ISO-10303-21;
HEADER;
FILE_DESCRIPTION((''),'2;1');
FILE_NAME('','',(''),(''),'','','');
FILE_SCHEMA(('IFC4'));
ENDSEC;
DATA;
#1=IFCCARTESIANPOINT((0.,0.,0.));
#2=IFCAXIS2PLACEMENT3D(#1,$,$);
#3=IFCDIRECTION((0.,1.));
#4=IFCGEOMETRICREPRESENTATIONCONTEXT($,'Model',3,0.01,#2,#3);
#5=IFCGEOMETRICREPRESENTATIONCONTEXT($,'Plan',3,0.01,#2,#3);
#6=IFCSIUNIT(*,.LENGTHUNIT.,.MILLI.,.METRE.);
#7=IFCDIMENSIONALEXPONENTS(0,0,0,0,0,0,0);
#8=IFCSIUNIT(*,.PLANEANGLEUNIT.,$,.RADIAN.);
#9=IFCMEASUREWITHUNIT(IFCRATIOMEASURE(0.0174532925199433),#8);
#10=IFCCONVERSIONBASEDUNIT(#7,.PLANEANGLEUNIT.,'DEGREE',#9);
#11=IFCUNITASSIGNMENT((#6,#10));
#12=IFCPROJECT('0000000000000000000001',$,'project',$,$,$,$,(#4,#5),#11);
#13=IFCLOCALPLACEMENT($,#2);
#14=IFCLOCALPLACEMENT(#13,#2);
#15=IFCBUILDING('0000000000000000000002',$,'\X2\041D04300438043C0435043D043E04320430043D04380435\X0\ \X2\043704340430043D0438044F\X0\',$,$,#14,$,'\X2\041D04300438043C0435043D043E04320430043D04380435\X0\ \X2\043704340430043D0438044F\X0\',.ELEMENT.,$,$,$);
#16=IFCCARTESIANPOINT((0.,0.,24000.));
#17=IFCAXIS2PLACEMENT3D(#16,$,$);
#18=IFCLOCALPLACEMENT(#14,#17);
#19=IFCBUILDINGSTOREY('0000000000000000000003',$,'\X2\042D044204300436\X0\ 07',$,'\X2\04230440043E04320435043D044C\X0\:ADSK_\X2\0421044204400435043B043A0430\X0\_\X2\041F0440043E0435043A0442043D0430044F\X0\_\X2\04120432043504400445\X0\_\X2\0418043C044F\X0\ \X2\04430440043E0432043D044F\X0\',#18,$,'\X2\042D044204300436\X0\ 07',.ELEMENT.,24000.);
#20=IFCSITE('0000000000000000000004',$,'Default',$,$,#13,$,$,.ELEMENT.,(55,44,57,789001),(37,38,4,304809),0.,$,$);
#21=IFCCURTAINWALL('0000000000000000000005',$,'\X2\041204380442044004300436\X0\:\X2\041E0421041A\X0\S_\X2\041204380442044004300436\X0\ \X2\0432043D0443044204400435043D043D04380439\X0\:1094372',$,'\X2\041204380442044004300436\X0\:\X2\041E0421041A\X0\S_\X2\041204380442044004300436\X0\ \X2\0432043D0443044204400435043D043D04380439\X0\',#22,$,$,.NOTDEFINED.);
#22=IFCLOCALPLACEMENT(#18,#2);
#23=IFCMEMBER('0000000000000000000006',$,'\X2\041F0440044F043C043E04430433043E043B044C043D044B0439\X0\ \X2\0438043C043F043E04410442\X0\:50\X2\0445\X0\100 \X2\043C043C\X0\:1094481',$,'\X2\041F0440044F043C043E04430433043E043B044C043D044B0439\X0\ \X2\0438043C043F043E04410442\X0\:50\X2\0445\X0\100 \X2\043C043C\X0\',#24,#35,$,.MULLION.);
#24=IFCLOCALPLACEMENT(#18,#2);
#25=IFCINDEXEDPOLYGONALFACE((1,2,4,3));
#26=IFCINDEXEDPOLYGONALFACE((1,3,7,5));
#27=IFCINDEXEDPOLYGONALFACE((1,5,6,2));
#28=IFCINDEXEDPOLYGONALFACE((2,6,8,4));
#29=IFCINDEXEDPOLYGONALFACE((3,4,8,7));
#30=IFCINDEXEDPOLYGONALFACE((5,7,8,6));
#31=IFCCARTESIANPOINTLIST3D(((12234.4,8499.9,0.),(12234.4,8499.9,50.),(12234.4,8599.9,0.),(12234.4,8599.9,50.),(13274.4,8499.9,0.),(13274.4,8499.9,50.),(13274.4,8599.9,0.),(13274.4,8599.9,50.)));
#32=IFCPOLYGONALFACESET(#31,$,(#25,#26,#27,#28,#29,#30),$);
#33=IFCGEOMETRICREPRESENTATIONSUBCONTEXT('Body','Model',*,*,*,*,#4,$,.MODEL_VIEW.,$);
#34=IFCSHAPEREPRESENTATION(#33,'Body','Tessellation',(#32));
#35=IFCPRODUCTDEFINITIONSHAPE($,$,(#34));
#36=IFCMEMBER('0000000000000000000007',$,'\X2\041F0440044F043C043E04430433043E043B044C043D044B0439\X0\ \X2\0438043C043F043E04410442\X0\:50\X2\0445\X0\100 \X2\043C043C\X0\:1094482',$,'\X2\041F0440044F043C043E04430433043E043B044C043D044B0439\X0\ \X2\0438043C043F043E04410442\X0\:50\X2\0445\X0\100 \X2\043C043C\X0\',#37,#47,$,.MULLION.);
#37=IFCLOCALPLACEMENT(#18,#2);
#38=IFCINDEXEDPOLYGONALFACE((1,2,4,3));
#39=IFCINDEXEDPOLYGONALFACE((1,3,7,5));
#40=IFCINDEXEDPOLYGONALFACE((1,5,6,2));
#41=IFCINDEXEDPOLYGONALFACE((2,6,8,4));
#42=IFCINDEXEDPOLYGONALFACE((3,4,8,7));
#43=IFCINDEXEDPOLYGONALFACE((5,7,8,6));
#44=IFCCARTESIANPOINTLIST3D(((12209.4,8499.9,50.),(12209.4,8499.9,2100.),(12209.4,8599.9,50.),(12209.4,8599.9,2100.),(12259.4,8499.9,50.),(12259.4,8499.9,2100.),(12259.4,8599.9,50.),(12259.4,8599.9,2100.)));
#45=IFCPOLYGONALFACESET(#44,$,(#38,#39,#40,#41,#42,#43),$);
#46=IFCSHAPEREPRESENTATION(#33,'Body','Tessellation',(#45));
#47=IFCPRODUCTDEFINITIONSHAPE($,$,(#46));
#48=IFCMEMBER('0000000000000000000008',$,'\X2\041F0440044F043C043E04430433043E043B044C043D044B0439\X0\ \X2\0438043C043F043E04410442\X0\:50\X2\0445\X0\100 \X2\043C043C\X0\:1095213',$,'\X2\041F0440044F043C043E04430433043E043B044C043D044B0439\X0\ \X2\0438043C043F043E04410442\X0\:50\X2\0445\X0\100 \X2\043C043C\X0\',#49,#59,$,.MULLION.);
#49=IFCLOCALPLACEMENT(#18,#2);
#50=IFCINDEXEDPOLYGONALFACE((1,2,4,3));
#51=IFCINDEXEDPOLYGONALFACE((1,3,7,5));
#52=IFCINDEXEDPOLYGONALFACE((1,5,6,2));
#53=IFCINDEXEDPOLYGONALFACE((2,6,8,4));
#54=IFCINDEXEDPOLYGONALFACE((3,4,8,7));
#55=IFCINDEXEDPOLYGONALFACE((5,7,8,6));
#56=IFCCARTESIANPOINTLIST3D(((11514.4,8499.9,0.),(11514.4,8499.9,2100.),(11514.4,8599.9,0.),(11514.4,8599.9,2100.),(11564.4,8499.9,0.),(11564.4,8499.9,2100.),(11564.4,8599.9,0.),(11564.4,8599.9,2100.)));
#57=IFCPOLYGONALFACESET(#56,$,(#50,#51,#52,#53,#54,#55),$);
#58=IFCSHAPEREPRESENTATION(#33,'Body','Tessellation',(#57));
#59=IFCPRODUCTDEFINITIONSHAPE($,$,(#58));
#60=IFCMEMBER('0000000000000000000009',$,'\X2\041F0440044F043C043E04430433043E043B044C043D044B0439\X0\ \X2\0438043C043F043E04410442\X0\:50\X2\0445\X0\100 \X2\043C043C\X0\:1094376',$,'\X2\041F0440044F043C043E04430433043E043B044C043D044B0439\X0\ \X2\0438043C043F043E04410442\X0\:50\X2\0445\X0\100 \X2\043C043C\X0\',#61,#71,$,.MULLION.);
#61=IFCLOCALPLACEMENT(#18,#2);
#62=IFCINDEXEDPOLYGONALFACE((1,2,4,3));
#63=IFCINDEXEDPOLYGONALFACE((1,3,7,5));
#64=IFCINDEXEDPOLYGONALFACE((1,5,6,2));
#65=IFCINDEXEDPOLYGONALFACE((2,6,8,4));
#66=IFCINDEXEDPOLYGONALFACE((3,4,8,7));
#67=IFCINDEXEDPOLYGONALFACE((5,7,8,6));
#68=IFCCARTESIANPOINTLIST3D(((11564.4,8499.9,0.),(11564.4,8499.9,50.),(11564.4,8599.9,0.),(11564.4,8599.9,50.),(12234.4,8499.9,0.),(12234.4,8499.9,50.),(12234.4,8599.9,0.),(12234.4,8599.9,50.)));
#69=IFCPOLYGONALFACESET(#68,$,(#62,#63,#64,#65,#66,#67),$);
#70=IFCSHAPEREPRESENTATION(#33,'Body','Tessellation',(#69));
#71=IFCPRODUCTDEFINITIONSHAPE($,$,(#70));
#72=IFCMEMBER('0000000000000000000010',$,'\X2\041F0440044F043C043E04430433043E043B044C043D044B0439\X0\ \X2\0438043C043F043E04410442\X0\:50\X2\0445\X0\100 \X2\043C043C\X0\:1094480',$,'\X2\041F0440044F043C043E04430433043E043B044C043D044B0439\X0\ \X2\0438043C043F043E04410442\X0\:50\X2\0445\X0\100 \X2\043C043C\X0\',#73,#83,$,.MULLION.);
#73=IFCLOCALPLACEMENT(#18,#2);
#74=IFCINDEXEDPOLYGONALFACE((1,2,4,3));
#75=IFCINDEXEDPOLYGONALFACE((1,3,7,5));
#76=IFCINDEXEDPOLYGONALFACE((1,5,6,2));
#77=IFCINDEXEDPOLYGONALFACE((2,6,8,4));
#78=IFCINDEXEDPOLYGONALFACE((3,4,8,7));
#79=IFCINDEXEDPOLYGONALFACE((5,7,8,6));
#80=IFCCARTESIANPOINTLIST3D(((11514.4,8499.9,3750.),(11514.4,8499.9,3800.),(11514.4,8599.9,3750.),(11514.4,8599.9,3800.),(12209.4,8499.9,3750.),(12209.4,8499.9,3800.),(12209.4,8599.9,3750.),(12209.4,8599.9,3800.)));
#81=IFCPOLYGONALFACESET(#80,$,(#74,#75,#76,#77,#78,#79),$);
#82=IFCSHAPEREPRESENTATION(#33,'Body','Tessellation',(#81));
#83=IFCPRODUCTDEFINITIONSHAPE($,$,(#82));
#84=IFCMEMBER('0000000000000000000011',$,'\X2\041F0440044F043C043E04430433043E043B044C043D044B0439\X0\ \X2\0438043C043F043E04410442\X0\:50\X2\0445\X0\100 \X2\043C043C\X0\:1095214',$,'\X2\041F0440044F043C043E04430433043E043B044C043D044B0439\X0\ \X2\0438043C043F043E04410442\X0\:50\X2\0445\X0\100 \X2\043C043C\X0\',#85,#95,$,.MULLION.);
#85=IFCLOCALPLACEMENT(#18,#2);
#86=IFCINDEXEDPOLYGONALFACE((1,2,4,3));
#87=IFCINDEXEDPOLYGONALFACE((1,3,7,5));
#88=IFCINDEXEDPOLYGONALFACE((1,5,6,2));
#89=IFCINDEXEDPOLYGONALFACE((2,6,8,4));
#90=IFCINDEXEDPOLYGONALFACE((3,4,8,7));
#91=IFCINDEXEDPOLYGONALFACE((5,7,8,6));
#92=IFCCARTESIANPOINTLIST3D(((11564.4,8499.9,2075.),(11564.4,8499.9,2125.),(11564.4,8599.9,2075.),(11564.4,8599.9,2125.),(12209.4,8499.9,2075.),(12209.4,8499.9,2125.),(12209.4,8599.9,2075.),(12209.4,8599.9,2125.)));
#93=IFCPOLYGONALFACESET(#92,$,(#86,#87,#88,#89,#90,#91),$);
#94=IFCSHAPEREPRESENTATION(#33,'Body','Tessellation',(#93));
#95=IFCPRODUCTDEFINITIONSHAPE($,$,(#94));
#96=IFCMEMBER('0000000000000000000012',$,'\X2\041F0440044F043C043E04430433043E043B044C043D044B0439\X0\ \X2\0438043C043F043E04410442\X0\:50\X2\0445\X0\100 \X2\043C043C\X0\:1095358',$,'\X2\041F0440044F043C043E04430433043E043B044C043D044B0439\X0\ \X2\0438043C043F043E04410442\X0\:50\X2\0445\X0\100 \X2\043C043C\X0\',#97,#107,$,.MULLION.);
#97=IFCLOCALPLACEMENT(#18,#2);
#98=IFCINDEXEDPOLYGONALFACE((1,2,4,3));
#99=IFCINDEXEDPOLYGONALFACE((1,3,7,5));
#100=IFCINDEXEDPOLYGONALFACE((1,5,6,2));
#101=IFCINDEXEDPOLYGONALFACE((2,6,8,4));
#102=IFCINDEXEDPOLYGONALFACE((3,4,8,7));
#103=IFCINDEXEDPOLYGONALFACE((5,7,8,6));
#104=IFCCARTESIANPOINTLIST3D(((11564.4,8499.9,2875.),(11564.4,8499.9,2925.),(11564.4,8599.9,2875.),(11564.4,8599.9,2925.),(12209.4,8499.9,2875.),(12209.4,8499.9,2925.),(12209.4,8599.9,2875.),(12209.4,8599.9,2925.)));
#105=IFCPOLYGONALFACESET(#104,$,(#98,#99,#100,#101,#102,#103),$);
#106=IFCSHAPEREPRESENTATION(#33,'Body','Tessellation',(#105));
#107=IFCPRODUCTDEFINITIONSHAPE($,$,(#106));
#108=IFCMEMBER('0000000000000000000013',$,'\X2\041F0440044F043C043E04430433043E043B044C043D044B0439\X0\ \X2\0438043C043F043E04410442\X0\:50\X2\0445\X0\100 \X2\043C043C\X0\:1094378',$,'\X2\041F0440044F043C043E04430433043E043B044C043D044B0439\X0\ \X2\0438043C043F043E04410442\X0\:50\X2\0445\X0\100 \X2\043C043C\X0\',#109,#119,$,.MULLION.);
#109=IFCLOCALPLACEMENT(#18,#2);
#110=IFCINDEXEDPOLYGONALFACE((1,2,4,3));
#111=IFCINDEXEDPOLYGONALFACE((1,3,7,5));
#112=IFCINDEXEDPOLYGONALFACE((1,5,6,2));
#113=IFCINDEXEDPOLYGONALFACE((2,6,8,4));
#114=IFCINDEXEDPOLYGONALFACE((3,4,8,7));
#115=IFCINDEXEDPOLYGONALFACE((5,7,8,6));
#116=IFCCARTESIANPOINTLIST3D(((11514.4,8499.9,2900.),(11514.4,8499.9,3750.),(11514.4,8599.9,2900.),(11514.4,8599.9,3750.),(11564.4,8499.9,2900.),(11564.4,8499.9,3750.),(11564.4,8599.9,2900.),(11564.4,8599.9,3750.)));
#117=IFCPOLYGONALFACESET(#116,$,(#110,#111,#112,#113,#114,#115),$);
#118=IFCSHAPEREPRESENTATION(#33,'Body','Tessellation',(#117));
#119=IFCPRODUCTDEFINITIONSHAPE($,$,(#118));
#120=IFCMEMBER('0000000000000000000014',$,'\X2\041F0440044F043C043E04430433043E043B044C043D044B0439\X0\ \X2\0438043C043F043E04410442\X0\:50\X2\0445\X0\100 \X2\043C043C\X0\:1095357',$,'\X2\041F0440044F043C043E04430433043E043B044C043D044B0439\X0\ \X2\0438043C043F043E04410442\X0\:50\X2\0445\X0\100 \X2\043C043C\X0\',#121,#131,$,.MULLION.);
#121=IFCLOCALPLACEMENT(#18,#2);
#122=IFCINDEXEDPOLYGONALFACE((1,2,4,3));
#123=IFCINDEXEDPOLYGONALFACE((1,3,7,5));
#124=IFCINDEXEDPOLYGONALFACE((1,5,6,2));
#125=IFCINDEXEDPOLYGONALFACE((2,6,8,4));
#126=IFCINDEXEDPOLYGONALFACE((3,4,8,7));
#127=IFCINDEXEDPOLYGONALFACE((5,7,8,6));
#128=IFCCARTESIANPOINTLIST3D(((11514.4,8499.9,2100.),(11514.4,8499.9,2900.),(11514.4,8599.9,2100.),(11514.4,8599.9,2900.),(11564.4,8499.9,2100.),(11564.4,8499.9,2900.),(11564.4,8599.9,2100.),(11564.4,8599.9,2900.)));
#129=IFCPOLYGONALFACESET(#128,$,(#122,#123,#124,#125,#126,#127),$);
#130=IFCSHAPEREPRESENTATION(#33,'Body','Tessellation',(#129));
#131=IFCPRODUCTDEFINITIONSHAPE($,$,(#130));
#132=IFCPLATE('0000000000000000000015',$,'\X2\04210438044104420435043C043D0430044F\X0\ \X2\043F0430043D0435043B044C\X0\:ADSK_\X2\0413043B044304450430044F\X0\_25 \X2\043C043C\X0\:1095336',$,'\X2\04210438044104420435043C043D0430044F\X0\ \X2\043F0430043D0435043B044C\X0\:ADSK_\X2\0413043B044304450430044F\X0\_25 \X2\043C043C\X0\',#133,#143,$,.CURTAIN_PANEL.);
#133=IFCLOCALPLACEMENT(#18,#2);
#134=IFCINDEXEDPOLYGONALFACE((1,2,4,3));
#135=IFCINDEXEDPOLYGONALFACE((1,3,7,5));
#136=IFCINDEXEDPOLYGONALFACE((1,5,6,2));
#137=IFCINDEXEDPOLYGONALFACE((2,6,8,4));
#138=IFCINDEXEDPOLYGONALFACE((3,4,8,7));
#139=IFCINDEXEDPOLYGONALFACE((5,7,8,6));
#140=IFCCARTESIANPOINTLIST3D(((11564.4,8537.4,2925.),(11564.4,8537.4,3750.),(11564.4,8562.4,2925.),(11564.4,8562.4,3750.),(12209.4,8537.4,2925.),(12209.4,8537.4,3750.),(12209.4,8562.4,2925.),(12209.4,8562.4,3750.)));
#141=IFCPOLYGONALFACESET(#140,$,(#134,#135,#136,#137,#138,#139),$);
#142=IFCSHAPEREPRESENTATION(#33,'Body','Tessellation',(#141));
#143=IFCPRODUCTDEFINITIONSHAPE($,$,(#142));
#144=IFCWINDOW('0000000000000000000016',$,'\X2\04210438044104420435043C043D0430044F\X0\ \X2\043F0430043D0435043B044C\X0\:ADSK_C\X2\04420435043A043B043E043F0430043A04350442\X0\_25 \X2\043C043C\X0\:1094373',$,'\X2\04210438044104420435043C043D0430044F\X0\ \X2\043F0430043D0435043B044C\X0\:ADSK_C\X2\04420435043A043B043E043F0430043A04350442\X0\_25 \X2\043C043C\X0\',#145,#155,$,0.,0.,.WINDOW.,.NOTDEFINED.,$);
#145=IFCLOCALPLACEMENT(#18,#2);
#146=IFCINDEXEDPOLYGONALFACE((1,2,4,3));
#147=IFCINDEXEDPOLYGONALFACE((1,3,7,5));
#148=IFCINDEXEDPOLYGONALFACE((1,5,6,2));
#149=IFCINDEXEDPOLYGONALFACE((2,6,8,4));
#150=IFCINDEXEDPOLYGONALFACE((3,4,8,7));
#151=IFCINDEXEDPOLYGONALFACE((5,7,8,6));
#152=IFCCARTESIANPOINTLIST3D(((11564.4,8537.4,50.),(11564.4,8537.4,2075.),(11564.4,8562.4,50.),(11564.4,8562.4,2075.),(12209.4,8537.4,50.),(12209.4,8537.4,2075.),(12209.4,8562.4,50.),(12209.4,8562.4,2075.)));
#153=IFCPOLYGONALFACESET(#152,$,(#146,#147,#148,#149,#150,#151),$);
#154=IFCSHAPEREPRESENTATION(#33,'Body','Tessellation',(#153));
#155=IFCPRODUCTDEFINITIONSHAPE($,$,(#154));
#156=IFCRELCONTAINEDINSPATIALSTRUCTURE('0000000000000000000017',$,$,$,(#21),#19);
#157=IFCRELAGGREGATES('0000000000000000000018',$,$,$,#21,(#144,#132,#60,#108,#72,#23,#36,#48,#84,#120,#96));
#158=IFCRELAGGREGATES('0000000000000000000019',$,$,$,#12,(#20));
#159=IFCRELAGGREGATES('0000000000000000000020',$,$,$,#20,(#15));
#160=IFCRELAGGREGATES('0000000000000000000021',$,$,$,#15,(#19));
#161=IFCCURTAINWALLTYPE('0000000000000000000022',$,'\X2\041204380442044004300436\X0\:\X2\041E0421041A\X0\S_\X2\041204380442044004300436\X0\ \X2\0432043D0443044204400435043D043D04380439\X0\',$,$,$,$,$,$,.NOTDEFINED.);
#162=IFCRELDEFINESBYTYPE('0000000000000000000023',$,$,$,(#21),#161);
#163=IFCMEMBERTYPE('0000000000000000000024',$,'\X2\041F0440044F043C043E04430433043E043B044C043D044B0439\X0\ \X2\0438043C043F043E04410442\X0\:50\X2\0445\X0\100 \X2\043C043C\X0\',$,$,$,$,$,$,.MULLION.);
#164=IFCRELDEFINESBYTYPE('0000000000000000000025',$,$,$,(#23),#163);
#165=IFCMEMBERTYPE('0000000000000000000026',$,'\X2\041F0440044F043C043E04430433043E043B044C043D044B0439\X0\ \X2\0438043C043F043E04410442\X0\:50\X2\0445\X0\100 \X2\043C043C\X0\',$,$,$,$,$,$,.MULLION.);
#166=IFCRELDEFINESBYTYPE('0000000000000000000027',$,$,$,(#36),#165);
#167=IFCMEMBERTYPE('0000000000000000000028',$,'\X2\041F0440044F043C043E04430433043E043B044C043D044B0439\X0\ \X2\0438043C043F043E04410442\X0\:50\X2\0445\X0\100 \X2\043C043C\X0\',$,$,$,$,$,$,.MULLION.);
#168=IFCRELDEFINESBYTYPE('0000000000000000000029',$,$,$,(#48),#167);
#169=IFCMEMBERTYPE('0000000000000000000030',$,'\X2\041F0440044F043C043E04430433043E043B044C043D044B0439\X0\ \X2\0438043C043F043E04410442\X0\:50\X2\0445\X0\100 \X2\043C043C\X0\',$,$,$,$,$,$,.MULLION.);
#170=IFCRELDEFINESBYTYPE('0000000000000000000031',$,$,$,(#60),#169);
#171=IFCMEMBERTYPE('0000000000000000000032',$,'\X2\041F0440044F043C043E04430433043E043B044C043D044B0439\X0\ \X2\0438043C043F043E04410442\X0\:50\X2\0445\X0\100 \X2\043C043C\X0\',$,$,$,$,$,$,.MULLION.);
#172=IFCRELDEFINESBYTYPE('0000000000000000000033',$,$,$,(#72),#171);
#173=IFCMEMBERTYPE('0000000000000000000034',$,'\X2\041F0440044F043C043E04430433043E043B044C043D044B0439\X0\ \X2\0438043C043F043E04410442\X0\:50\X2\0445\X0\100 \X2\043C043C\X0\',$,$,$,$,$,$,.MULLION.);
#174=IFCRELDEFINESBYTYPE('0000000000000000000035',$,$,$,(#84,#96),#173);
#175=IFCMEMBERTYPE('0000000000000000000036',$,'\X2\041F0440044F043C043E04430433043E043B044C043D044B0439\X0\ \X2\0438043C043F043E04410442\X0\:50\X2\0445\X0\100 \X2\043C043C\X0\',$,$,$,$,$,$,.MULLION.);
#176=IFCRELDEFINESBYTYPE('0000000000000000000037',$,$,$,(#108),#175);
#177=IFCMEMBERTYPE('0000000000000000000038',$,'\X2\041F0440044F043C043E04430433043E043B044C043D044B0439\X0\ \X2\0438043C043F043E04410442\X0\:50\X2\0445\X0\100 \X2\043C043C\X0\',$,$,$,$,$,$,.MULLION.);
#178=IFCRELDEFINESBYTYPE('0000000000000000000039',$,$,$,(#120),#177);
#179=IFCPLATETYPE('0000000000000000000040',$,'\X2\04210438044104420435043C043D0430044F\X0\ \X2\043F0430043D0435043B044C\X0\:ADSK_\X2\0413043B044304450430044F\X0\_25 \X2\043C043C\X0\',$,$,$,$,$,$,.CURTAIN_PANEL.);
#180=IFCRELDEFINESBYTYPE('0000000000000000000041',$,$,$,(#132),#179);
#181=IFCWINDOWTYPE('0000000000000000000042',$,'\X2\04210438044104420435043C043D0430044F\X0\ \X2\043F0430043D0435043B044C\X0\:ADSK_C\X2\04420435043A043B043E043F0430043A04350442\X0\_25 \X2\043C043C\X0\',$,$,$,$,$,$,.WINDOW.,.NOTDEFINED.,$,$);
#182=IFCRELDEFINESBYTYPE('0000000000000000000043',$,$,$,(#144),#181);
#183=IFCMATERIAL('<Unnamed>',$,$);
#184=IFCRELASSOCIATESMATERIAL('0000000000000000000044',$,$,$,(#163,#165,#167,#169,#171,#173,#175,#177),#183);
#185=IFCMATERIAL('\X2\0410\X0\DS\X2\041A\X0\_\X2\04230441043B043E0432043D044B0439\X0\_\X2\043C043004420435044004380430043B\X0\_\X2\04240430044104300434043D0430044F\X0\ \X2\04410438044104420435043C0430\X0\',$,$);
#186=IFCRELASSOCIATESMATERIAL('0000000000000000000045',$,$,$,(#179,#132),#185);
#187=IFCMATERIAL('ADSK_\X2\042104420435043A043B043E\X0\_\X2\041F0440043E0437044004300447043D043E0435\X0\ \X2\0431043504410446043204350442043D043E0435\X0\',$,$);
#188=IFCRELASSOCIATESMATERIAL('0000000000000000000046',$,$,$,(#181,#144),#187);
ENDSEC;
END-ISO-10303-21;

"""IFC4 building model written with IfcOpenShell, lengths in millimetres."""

from ifc_helpers import new_model, entity, si_unit, converted_unit, direction, frame, origin, place, context, subcontext, project, spatial, indexed_curve, outline, extrude, source, transform, mapped, material, type_object, type_shapes, element, aggregate, save


model = new_model("IFC4")

# Units and contexts
model_context = context("Model", 3, precision=0.01, world=origin(), true_north=direction((0.0, 1.0)))
plan_context = context("Plan", 3, precision=0.01, world=origin(), true_north=direction((0.0, 1.0)))
body_context = subcontext(model_context, "Body", "Model", "MODEL_VIEW")
ifc_project = project(units=[si_unit("LENGTHUNIT", "METRE", prefix="MILLI"), converted_unit("PLANEANGLEUNIT", "DEGREE", entity("IfcRatioMeasure", 0.0174532925199433), si_unit("PLANEANGLEUNIT", "RADIAN"), dimensions=[0, 0, 0, 0, 0, 0, 0])], contexts=[model_context, plan_context])

# Site, building, storey
site_placement = place(None, frame((0.0, 0.0, 0.0)))
site = spatial("IfcSite", under=ifc_project, at=site_placement, Name="Default", CompositionType="ELEMENT", RefLatitude=(55, 44, 57, 789001), RefLongitude=(37, 38, 4, 304809), RefElevation=0.0)
building_placement = place(site_placement, origin())
building = spatial("IfcBuilding", under=site, at=building_placement, Name="Наименование здания", LongName="Наименование здания", CompositionType="ELEMENT")
storey_placement = place(building_placement, frame((0.0, 0.0, 24000.0)))
storey = spatial("IfcBuildingStorey", under=building, at=storey_placement, Name="Этаж 07", ObjectType="Уровень:ADSK_Стрелка_Проектная_Вверх_Имя уровня", LongName="Этаж 07", CompositionType="ELEMENT", Elevation=24000.0)

# Curtain wall, members, plate
curtain_wall_type = type_object("IfcCurtainWallType", Name="Витраж:ОСКS_Витраж внутренний", PredefinedType="NOTDEFINED")
curtain_wall_placement = place(storey_placement, frame((0.0, 0.0, -24000.0)))
curtain_wall = element("IfcCurtainWall", 1, at=curtain_wall_placement, inside=storey, type_object=curtain_wall_type, Name="Витраж:ОСКS_Витраж внутренний:1094372", ObjectType="Витраж:ОСКS_Витраж внутренний", PredefinedType="NOTDEFINED")
ifc_material_1 = material(Name="<Unnamed>")
member_type_1 = type_object("IfcMemberType", Name="Прямоугольный импост:50х100 мм", PredefinedType="MULLION", material=ifc_material_1)
shared_shape_1 = source(origin(), body_context, "Body", "SweptSolid", [
    extrude(outline(indexed_curve([(-50.0, -25.0), (50.0, -25.0), (50.0, 25.0), (-50.0, 25.0), (-50.0, -25.0)], self_intersect=False)), frame((-25.0, 0.0, -1040.0), z_axis=(0.0, 0.0, 1.0), x_axis=(0.0, -1.0, 0.0)), (0.0, 0.0, 1.0), 1040.0),
])
type_shapes(member_type_1, [shared_shape_1])
member_1_placement = place(storey_placement, frame((12234.4, 8549.9, 0.0), z_axis=(-1.0, 0.0, 0.0), x_axis=(0.0, 0.0, -1.0)))
member_1 = element("IfcMember", 2, at=member_1_placement, type_object=member_type_1, Name="Прямоугольный импост:50х100 мм:1094481", ObjectType="Прямоугольный импост:50х100 мм", PredefinedType="MULLION", context=body_context, shape_type="MappedRepresentation", body=[
    mapped(shared_shape_1, transform((0.0, 0.0, 0.0), scale=1.0)),
])
member_type_2 = type_object("IfcMemberType", Name="Прямоугольный импост:50х100 мм", PredefinedType="MULLION", material=ifc_material_1)
shared_shape_2 = source(origin(), body_context, "Body", "SweptSolid", [
    extrude(outline(indexed_curve([(-50.0, -25.0), (50.0, -25.0), (50.0, 25.0), (-50.0, 25.0), (-50.0, -25.0)], self_intersect=False)), frame((0.0, 0.0, -2050.0), z_axis=(0.0, 0.0, 1.0), x_axis=(0.0, -1.0, 0.0)), (0.0, 0.0, 1.0), 2050.0),
])
type_shapes(member_type_2, [shared_shape_2])
member_2_placement = place(storey_placement, frame((12234.4, 8549.9, 50.0), z_axis=(0.0, 0.0, -1.0), x_axis=(1.0, 0.0, 0.0)))
member_2 = element("IfcMember", 3, at=member_2_placement, type_object=member_type_2, Name="Прямоугольный импост:50х100 мм:1094482", ObjectType="Прямоугольный импост:50х100 мм", PredefinedType="MULLION", context=body_context, shape_type="MappedRepresentation", body=[
    mapped(shared_shape_2, transform((0.0, 0.0, 0.0), scale=1.0)),
])
member_type_3 = type_object("IfcMemberType", Name="Прямоугольный импост:50х100 мм", PredefinedType="MULLION", material=ifc_material_1)
shared_shape_3 = source(origin(), body_context, "Body", "SweptSolid", [
    extrude(outline(indexed_curve([(-50.0, -25.0), (50.0, -25.0), (50.0, 25.0), (-50.0, 25.0), (-50.0, -25.0)], self_intersect=False)), frame((-25.0, 0.0, -2100.0), z_axis=(0.0, 0.0, 1.0), x_axis=(0.0, -1.0, 0.0)), (0.0, 0.0, 1.0), 2100.0),
])
type_shapes(member_type_3, [shared_shape_3])
member_3_placement = place(storey_placement, frame((11514.4, 8549.9, 2100.0), z_axis=(0.0, 0.0, 1.0), x_axis=(-1.0, 0.0, 0.0)))
member_3 = element("IfcMember", 4, at=member_3_placement, type_object=member_type_3, Name="Прямоугольный импост:50х100 мм:1095213", ObjectType="Прямоугольный импост:50х100 мм", PredefinedType="MULLION", context=body_context, shape_type="MappedRepresentation", body=[
    mapped(shared_shape_3, transform((0.0, 0.0, 0.0), scale=1.0)),
])
member_type_4 = type_object("IfcMemberType", Name="Прямоугольный импост:50х100 мм", PredefinedType="MULLION", material=ifc_material_1)
shared_shape_4 = source(origin(), body_context, "Body", "SweptSolid", [
    extrude(outline(indexed_curve([(-50.0, -25.0), (50.0, -25.0), (50.0, 25.0), (-50.0, 25.0), (-50.0, -25.0)], self_intersect=False)), frame((-25.0, 0.0, -670.0), z_axis=(0.0, 0.0, 1.0), x_axis=(0.0, -1.0, 0.0)), (0.0, 0.0, 1.0), 670.0),
])
type_shapes(member_type_4, [shared_shape_4])
member_4_placement = place(storey_placement, frame((11564.4, 8549.9, 0.0), z_axis=(-1.0, 0.0, 0.0), x_axis=(0.0, 0.0, -1.0)))
member_4 = element("IfcMember", 5, at=member_4_placement, type_object=member_type_4, Name="Прямоугольный импост:50х100 мм:1094376", ObjectType="Прямоугольный импост:50х100 мм", PredefinedType="MULLION", context=body_context, shape_type="MappedRepresentation", body=[
    mapped(shared_shape_4, transform((0.0, 0.0, 0.0), scale=1.0)),
])
member_type_5 = type_object("IfcMemberType", Name="Прямоугольный импост:50х100 мм", PredefinedType="MULLION", material=ifc_material_1)
shared_shape_5 = source(origin(), body_context, "Body", "SweptSolid", [
    extrude(outline(indexed_curve([(-50.0, -25.0), (50.0, -25.0), (50.0, 25.0), (-50.0, 25.0), (-50.0, -25.0)], self_intersect=False)), frame((-25.0, 0.0, -695.0), z_axis=(0.0, 0.0, 1.0), x_axis=(0.0, -1.0, 0.0)), (0.0, 0.0, 1.0), 695.0),
])
type_shapes(member_type_5, [shared_shape_5])
member_5_placement = place(storey_placement, frame((12209.4, 8549.9, 3800.0), z_axis=(1.0, 0.0, 0.0), x_axis=(0.0, 0.0, 1.0)))
member_5 = element("IfcMember", 6, at=member_5_placement, type_object=member_type_5, Name="Прямоугольный импост:50х100 мм:1094480", ObjectType="Прямоугольный импост:50х100 мм", PredefinedType="MULLION", context=body_context, shape_type="MappedRepresentation", body=[
    mapped(shared_shape_5, transform((0.0, 0.0, 0.0), scale=1.0)),
])
member_type_6 = type_object("IfcMemberType", Name="Прямоугольный импост:50х100 мм", PredefinedType="MULLION", material=ifc_material_1)
shared_shape_6 = source(origin(), body_context, "Body", "SweptSolid", [
    extrude(outline(indexed_curve([(-50.0, -25.0), (50.0, -25.0), (50.0, 25.0), (-50.0, 25.0), (-50.0, -25.0)], self_intersect=False)), frame((0.0, 0.0, -645.0), z_axis=(0.0, 0.0, 1.0), x_axis=(0.0, -1.0, 0.0)), (0.0, 0.0, 1.0), 645.0),
])
type_shapes(member_type_6, [shared_shape_6])
member_6_placement = place(storey_placement, frame((12209.4, 8549.9, 2100.0), z_axis=(1.0, 0.0, 0.0), x_axis=(0.0, 0.0, 1.0)))
member_6 = element("IfcMember", 7, at=member_6_placement, type_object=member_type_6, Name="Прямоугольный импост:50х100 мм:1095214", ObjectType="Прямоугольный импост:50х100 мм", PredefinedType="MULLION", context=body_context, shape_type="MappedRepresentation", body=[
    mapped(shared_shape_6, transform((0.0, 0.0, 0.0), scale=1.0)),
])
member_7_placement = place(storey_placement, frame((12209.4, 8549.9, 2900.0), z_axis=(1.0, 0.0, 0.0), x_axis=(0.0, 0.0, 1.0)))
member_7 = element("IfcMember", 8, at=member_7_placement, type_object=member_type_6, Name="Прямоугольный импост:50х100 мм:1095358", ObjectType="Прямоугольный импост:50х100 мм", PredefinedType="MULLION", context=body_context, shape_type="MappedRepresentation", body=[
    mapped(shared_shape_6, transform((0.0, 0.0, 0.0), scale=1.0)),
])
member_type_7 = type_object("IfcMemberType", Name="Прямоугольный импост:50х100 мм", PredefinedType="MULLION", material=ifc_material_1)
shared_shape_7 = source(origin(), body_context, "Body", "SweptSolid", [
    extrude(outline(indexed_curve([(-50.0, -25.0), (50.0, -25.0), (50.0, 25.0), (-50.0, 25.0), (-50.0, -25.0)], self_intersect=False)), frame((-25.0, 0.0, -850.0), z_axis=(0.0, 0.0, 1.0), x_axis=(0.0, -1.0, 0.0)), (0.0, 0.0, 1.0), 850.0),
])
type_shapes(member_type_7, [shared_shape_7])
member_8_placement = place(storey_placement, frame((11514.4, 8549.9, 3750.0), z_axis=(0.0, 0.0, 1.0), x_axis=(-1.0, 0.0, 0.0)))
member_8 = element("IfcMember", 9, at=member_8_placement, type_object=member_type_7, Name="Прямоугольный импост:50х100 мм:1094378", ObjectType="Прямоугольный импост:50х100 мм", PredefinedType="MULLION", context=body_context, shape_type="MappedRepresentation", body=[
    mapped(shared_shape_7, transform((0.0, 0.0, 0.0), scale=1.0)),
])
member_type_8 = type_object("IfcMemberType", Name="Прямоугольный импост:50х100 мм", PredefinedType="MULLION", material=ifc_material_1)
shared_shape_8 = source(origin(), body_context, "Body", "SweptSolid", [
    extrude(outline(indexed_curve([(-50.0, -25.0), (50.0, -25.0), (50.0, 25.0), (-50.0, 25.0), (-50.0, -25.0)], self_intersect=False)), frame((-25.0, 0.0, -800.0), z_axis=(0.0, 0.0, 1.0), x_axis=(0.0, -1.0, 0.0)), (0.0, 0.0, 1.0), 800.0),
])
type_shapes(member_type_8, [shared_shape_8])
member_9_placement = place(storey_placement, frame((11514.4, 8549.9, 2900.0), z_axis=(0.0, 0.0, 1.0), x_axis=(-1.0, 0.0, 0.0)))
member_9 = element("IfcMember", 10, at=member_9_placement, type_object=member_type_8, Name="Прямоугольный импост:50х100 мм:1095357", ObjectType="Прямоугольный импост:50х100 мм", PredefinedType="MULLION", context=body_context, shape_type="MappedRepresentation", body=[
    mapped(shared_shape_8, transform((0.0, 0.0, 0.0), scale=1.0)),
])
ifc_material_2 = material(Name="АDSК_Условный_материал_Фасадная система")
plate_type = type_object("IfcPlateType", Name="Системная панель:ADSK_Глухая_25 мм", PredefinedType="CURTAIN_PANEL", material=ifc_material_2)
shared_shape_9 = source(origin(), body_context, "Body", "SweptSolid", [
    extrude(outline(indexed_curve([(-12.5, -322.5), (12.5, -322.5), (12.5, 322.5), (-12.5, 322.5), (-12.5, -322.5)], self_intersect=False)), frame((0.0, 0.0, 0.0), z_axis=(0.0, 0.0, 1.0), x_axis=(0.0, 1.0, 0.0)), (0.0, 0.0, 1.0), 825.0),
])
type_shapes(plate_type, [shared_shape_9])
plate_placement = place(curtain_wall_placement, frame((11886.9, 8549.9, 26925.0)))
plate = element("IfcPlate", 11, at=plate_placement, type_object=plate_type, material=ifc_material_2, Name="Системная панель:ADSK_Глухая_25 мм:1095336", ObjectType="Системная панель:ADSK_Глухая_25 мм", PredefinedType="CURTAIN_PANEL", context=body_context, shape_type="MappedRepresentation", body=[
    mapped(shared_shape_9, transform((0.0, 0.0, 0.0), scale=1.0)),
])

# Window
ifc_material_3 = material(Name="ADSK_Стекло_Прозрачное бесцветное")
window_type_1 = type_object("IfcWindowType", Name="Системная панель:ADSK_Cтеклопакет_25 мм", PartitioningType="NOTDEFINED", PredefinedType="WINDOW", material=ifc_material_3)
shared_shape_10 = source(origin(), body_context, "Body", "SweptSolid", [
    extrude(outline(indexed_curve([(-12.5, -322.5), (12.5, -322.5), (12.5, 322.5), (-12.5, 322.5), (-12.5, -322.5)], self_intersect=False)), frame((0.0, 0.0, 0.0), z_axis=(0.0, 0.0, 1.0), x_axis=(0.0, 1.0, 0.0)), (0.0, 0.0, 1.0), 2025.0),
])
type_shapes(window_type_1, [shared_shape_10])
window_1_placement = place(curtain_wall_placement, frame((11886.9, 8549.9, 24050.0)))
window_1 = element("IfcWindow", 12, at=window_1_placement, type_object=window_type_1, material=ifc_material_3, Name="Системная панель:ADSK_Cтеклопакет_25 мм:1094373", ObjectType="Системная панель:ADSK_Cтеклопакет_25 мм", OverallHeight=0.0, OverallWidth=0.0, PartitioningType="NOTDEFINED", PredefinedType="WINDOW", context=body_context, shape_type="MappedRepresentation", body=[
    mapped(shared_shape_10, transform((0.0, 0.0, 0.0), scale=1.0)),
])
aggregate(curtain_wall, [window_1, plate, member_4, member_8, member_5, member_1, member_2, member_3, member_6, member_9, member_7])

save(model, "model.ifc")
